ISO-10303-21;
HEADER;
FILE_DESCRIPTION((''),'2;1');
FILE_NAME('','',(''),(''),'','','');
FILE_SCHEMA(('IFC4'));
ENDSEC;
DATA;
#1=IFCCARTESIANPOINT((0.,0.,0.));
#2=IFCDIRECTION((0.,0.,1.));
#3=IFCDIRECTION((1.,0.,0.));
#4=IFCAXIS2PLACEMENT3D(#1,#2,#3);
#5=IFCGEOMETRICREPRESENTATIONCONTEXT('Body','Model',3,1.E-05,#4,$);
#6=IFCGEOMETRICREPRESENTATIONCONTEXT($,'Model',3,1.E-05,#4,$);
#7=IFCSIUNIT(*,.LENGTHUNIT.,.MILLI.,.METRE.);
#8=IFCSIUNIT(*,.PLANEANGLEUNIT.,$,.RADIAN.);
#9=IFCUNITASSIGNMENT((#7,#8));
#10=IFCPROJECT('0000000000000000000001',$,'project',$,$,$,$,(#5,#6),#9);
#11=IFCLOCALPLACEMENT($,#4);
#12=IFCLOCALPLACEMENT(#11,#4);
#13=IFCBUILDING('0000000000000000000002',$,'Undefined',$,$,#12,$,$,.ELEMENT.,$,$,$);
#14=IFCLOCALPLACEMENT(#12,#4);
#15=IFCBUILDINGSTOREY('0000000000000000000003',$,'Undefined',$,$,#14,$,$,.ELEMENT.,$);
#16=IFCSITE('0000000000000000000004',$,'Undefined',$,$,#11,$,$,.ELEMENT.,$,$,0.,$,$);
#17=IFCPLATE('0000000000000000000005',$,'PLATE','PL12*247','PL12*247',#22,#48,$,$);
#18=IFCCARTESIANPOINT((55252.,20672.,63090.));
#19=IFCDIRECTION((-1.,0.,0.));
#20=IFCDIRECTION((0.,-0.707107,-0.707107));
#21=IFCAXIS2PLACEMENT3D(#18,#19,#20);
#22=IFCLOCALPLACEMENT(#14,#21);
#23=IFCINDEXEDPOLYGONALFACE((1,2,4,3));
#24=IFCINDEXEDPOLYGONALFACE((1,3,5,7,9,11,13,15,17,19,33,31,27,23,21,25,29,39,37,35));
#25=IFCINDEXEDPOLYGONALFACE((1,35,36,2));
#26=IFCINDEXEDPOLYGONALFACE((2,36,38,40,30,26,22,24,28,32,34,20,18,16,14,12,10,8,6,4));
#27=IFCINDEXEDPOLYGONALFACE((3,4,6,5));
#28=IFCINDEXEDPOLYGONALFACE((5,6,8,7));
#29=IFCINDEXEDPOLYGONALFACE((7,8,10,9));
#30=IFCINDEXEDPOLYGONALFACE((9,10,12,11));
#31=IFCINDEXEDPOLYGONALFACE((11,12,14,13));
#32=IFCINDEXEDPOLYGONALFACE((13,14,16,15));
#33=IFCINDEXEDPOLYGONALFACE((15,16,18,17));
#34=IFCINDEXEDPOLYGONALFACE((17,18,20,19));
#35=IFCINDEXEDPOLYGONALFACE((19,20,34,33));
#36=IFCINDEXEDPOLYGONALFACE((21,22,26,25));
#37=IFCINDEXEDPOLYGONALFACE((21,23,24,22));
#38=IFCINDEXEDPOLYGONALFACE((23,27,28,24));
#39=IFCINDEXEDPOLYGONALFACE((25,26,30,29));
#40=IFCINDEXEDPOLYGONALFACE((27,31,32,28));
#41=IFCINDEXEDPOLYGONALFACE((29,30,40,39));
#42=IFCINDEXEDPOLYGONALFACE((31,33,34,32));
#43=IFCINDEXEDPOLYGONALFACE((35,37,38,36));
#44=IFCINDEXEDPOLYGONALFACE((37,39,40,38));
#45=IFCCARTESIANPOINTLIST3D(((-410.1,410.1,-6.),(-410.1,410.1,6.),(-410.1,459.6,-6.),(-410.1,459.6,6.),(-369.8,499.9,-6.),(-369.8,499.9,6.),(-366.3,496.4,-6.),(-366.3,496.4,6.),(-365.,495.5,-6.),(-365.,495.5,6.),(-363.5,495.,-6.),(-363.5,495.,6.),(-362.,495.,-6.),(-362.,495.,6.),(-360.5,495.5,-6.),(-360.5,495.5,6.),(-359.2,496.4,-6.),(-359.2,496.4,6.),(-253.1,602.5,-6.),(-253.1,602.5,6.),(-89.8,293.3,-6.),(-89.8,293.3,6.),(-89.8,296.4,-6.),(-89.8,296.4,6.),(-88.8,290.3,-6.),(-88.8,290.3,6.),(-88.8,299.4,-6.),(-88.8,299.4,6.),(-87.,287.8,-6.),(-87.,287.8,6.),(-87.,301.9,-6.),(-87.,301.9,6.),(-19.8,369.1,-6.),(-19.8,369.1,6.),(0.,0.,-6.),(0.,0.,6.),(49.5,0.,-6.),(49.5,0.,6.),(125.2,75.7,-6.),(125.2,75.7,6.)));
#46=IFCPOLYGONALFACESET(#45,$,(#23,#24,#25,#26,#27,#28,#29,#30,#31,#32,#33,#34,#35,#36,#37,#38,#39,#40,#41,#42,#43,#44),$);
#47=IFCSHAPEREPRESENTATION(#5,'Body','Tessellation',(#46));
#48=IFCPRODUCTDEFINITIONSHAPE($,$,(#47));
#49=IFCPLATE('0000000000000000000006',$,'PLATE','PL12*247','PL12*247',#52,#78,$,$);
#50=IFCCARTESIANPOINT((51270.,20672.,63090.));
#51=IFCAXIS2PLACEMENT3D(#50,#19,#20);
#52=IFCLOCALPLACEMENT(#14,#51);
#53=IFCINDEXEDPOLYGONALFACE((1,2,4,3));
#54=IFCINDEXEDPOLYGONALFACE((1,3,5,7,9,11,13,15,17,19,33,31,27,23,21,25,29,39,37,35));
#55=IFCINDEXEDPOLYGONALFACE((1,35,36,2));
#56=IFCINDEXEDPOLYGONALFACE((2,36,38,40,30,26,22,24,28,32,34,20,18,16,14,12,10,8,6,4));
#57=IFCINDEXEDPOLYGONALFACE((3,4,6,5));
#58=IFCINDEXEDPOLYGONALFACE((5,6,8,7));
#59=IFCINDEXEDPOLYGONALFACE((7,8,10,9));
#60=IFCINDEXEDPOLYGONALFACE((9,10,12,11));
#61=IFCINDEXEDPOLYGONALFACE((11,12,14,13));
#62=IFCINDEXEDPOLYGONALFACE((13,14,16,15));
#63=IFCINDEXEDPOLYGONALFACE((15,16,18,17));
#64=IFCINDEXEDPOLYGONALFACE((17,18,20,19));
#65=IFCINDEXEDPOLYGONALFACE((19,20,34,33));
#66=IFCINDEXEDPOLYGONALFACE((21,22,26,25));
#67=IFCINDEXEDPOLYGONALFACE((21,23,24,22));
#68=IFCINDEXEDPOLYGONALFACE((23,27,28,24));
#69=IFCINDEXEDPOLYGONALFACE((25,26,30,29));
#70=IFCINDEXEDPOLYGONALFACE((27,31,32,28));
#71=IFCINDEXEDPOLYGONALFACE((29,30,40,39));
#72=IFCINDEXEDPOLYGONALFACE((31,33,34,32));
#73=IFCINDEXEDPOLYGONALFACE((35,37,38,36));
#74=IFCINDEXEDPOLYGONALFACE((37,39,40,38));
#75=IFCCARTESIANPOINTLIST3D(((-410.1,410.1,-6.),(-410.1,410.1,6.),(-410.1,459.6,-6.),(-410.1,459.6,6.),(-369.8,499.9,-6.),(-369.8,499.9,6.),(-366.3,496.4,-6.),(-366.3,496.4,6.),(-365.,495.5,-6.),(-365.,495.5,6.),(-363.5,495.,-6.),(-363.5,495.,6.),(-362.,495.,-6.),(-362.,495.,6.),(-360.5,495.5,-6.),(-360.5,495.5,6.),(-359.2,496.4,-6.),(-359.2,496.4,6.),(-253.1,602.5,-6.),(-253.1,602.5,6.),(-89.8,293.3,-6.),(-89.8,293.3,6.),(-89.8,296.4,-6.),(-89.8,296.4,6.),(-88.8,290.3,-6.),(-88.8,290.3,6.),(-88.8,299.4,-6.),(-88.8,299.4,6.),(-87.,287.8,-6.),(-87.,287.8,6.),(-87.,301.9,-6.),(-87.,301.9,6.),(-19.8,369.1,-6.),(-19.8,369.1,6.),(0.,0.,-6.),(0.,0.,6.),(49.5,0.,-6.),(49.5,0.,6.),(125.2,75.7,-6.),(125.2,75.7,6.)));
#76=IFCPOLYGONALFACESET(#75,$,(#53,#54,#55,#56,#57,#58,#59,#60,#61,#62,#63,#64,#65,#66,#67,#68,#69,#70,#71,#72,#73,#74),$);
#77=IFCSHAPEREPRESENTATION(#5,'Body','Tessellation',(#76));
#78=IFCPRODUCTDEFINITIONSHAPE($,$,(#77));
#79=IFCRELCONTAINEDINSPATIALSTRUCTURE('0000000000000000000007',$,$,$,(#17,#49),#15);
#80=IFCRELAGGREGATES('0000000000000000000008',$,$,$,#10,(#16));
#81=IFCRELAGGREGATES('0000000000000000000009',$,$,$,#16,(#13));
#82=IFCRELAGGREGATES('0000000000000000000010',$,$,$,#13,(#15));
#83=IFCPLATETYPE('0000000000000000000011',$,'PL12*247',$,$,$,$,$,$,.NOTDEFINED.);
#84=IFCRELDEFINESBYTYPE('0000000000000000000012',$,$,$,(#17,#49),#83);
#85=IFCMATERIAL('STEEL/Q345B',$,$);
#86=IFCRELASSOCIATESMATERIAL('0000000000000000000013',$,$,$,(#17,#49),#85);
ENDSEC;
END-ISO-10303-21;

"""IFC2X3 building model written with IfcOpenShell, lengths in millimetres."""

from ifc_helpers import new_model, si_unit, frame, origin_with_axes, place, context, project, spatial, polyline, outline, extrude, material, type_object, element, save


model = new_model("IFC2X3")

# Units and contexts
model_context_1 = context("Model", 3, precision=1e-05, world=origin_with_axes(), identifier="Body")
model_context_2 = context("Model", 3, precision=1e-05, world=origin_with_axes())
ifc_project = project(units=[si_unit("LENGTHUNIT", "METRE", prefix="MILLI"), si_unit("PLANEANGLEUNIT", "RADIAN")], contexts=[model_context_1, model_context_2])

# Site, building, storey
site_placement = place(None, origin_with_axes())
site = spatial("IfcSite", under=ifc_project, at=site_placement, Name="Undefined", CompositionType="ELEMENT", RefElevation=0.0)
building_placement = place(site_placement, origin_with_axes())
building = spatial("IfcBuilding", under=site, at=building_placement, Name="Undefined", CompositionType="ELEMENT")
storey_placement = place(building_placement, origin_with_axes())
storey = spatial("IfcBuildingStorey", under=building, at=storey_placement, Name="Undefined", CompositionType="ELEMENT")

# Shared definitions
ifc_material_1 = material(Name="STEEL/Q345B")

# Plates
plate_type_1 = type_object("IfcPlateType", Name="PL12*247", PredefinedType="NOTDEFINED")
for number, where, z_axis, x_axis, name in (
    (1, (55252.0, 20672.0, 63090.0), (-1.0, 0.0, 0.0), (0.0, -0.707107, -0.707107), "PLATE"),
    (2, (51270.0, 20672.0, 63090.0), (-1.0, 0.0, 0.0), (0.0, -0.707107, -0.707107), "PLATE"),
):
    element("IfcPlate", number, at=place(storey_placement, frame(where, z_axis=z_axis, x_axis=x_axis)), inside=storey, type_object=plate_type_1, material=ifc_material_1, Name=name, Description="PL12*247", ObjectType="PL12*247", context=model_context_1, shape_type="SweptSolid", body=[
        extrude(outline(polyline([(0.0, 0.0), (49.5, 0.0), (125.2, 75.7), (-87.0, 287.8), (-88.8, 290.3), (-89.8, 293.3), (-89.8, 296.4), (-88.8, 299.4), (-87.0, 301.9), (-19.8, 369.1), (-253.1, 602.5), (-359.2, 496.4), (-360.5, 495.5), (-362.0, 495.0), (-363.5, 495.0), (-365.0, 495.5), (-366.3, 496.4), (-369.8, 499.9), (-410.1, 459.6), (-410.1, 410.1), (0.0, 0.0)])), frame((0.0, 0.0, -6.0), z_axis=(0.0, 0.0, 1.0), x_axis=(1.0, 0.0, 0.0)), (0.0, 0.0, 1.0), 12.0),
    ])

save(model, "model.ifc")
